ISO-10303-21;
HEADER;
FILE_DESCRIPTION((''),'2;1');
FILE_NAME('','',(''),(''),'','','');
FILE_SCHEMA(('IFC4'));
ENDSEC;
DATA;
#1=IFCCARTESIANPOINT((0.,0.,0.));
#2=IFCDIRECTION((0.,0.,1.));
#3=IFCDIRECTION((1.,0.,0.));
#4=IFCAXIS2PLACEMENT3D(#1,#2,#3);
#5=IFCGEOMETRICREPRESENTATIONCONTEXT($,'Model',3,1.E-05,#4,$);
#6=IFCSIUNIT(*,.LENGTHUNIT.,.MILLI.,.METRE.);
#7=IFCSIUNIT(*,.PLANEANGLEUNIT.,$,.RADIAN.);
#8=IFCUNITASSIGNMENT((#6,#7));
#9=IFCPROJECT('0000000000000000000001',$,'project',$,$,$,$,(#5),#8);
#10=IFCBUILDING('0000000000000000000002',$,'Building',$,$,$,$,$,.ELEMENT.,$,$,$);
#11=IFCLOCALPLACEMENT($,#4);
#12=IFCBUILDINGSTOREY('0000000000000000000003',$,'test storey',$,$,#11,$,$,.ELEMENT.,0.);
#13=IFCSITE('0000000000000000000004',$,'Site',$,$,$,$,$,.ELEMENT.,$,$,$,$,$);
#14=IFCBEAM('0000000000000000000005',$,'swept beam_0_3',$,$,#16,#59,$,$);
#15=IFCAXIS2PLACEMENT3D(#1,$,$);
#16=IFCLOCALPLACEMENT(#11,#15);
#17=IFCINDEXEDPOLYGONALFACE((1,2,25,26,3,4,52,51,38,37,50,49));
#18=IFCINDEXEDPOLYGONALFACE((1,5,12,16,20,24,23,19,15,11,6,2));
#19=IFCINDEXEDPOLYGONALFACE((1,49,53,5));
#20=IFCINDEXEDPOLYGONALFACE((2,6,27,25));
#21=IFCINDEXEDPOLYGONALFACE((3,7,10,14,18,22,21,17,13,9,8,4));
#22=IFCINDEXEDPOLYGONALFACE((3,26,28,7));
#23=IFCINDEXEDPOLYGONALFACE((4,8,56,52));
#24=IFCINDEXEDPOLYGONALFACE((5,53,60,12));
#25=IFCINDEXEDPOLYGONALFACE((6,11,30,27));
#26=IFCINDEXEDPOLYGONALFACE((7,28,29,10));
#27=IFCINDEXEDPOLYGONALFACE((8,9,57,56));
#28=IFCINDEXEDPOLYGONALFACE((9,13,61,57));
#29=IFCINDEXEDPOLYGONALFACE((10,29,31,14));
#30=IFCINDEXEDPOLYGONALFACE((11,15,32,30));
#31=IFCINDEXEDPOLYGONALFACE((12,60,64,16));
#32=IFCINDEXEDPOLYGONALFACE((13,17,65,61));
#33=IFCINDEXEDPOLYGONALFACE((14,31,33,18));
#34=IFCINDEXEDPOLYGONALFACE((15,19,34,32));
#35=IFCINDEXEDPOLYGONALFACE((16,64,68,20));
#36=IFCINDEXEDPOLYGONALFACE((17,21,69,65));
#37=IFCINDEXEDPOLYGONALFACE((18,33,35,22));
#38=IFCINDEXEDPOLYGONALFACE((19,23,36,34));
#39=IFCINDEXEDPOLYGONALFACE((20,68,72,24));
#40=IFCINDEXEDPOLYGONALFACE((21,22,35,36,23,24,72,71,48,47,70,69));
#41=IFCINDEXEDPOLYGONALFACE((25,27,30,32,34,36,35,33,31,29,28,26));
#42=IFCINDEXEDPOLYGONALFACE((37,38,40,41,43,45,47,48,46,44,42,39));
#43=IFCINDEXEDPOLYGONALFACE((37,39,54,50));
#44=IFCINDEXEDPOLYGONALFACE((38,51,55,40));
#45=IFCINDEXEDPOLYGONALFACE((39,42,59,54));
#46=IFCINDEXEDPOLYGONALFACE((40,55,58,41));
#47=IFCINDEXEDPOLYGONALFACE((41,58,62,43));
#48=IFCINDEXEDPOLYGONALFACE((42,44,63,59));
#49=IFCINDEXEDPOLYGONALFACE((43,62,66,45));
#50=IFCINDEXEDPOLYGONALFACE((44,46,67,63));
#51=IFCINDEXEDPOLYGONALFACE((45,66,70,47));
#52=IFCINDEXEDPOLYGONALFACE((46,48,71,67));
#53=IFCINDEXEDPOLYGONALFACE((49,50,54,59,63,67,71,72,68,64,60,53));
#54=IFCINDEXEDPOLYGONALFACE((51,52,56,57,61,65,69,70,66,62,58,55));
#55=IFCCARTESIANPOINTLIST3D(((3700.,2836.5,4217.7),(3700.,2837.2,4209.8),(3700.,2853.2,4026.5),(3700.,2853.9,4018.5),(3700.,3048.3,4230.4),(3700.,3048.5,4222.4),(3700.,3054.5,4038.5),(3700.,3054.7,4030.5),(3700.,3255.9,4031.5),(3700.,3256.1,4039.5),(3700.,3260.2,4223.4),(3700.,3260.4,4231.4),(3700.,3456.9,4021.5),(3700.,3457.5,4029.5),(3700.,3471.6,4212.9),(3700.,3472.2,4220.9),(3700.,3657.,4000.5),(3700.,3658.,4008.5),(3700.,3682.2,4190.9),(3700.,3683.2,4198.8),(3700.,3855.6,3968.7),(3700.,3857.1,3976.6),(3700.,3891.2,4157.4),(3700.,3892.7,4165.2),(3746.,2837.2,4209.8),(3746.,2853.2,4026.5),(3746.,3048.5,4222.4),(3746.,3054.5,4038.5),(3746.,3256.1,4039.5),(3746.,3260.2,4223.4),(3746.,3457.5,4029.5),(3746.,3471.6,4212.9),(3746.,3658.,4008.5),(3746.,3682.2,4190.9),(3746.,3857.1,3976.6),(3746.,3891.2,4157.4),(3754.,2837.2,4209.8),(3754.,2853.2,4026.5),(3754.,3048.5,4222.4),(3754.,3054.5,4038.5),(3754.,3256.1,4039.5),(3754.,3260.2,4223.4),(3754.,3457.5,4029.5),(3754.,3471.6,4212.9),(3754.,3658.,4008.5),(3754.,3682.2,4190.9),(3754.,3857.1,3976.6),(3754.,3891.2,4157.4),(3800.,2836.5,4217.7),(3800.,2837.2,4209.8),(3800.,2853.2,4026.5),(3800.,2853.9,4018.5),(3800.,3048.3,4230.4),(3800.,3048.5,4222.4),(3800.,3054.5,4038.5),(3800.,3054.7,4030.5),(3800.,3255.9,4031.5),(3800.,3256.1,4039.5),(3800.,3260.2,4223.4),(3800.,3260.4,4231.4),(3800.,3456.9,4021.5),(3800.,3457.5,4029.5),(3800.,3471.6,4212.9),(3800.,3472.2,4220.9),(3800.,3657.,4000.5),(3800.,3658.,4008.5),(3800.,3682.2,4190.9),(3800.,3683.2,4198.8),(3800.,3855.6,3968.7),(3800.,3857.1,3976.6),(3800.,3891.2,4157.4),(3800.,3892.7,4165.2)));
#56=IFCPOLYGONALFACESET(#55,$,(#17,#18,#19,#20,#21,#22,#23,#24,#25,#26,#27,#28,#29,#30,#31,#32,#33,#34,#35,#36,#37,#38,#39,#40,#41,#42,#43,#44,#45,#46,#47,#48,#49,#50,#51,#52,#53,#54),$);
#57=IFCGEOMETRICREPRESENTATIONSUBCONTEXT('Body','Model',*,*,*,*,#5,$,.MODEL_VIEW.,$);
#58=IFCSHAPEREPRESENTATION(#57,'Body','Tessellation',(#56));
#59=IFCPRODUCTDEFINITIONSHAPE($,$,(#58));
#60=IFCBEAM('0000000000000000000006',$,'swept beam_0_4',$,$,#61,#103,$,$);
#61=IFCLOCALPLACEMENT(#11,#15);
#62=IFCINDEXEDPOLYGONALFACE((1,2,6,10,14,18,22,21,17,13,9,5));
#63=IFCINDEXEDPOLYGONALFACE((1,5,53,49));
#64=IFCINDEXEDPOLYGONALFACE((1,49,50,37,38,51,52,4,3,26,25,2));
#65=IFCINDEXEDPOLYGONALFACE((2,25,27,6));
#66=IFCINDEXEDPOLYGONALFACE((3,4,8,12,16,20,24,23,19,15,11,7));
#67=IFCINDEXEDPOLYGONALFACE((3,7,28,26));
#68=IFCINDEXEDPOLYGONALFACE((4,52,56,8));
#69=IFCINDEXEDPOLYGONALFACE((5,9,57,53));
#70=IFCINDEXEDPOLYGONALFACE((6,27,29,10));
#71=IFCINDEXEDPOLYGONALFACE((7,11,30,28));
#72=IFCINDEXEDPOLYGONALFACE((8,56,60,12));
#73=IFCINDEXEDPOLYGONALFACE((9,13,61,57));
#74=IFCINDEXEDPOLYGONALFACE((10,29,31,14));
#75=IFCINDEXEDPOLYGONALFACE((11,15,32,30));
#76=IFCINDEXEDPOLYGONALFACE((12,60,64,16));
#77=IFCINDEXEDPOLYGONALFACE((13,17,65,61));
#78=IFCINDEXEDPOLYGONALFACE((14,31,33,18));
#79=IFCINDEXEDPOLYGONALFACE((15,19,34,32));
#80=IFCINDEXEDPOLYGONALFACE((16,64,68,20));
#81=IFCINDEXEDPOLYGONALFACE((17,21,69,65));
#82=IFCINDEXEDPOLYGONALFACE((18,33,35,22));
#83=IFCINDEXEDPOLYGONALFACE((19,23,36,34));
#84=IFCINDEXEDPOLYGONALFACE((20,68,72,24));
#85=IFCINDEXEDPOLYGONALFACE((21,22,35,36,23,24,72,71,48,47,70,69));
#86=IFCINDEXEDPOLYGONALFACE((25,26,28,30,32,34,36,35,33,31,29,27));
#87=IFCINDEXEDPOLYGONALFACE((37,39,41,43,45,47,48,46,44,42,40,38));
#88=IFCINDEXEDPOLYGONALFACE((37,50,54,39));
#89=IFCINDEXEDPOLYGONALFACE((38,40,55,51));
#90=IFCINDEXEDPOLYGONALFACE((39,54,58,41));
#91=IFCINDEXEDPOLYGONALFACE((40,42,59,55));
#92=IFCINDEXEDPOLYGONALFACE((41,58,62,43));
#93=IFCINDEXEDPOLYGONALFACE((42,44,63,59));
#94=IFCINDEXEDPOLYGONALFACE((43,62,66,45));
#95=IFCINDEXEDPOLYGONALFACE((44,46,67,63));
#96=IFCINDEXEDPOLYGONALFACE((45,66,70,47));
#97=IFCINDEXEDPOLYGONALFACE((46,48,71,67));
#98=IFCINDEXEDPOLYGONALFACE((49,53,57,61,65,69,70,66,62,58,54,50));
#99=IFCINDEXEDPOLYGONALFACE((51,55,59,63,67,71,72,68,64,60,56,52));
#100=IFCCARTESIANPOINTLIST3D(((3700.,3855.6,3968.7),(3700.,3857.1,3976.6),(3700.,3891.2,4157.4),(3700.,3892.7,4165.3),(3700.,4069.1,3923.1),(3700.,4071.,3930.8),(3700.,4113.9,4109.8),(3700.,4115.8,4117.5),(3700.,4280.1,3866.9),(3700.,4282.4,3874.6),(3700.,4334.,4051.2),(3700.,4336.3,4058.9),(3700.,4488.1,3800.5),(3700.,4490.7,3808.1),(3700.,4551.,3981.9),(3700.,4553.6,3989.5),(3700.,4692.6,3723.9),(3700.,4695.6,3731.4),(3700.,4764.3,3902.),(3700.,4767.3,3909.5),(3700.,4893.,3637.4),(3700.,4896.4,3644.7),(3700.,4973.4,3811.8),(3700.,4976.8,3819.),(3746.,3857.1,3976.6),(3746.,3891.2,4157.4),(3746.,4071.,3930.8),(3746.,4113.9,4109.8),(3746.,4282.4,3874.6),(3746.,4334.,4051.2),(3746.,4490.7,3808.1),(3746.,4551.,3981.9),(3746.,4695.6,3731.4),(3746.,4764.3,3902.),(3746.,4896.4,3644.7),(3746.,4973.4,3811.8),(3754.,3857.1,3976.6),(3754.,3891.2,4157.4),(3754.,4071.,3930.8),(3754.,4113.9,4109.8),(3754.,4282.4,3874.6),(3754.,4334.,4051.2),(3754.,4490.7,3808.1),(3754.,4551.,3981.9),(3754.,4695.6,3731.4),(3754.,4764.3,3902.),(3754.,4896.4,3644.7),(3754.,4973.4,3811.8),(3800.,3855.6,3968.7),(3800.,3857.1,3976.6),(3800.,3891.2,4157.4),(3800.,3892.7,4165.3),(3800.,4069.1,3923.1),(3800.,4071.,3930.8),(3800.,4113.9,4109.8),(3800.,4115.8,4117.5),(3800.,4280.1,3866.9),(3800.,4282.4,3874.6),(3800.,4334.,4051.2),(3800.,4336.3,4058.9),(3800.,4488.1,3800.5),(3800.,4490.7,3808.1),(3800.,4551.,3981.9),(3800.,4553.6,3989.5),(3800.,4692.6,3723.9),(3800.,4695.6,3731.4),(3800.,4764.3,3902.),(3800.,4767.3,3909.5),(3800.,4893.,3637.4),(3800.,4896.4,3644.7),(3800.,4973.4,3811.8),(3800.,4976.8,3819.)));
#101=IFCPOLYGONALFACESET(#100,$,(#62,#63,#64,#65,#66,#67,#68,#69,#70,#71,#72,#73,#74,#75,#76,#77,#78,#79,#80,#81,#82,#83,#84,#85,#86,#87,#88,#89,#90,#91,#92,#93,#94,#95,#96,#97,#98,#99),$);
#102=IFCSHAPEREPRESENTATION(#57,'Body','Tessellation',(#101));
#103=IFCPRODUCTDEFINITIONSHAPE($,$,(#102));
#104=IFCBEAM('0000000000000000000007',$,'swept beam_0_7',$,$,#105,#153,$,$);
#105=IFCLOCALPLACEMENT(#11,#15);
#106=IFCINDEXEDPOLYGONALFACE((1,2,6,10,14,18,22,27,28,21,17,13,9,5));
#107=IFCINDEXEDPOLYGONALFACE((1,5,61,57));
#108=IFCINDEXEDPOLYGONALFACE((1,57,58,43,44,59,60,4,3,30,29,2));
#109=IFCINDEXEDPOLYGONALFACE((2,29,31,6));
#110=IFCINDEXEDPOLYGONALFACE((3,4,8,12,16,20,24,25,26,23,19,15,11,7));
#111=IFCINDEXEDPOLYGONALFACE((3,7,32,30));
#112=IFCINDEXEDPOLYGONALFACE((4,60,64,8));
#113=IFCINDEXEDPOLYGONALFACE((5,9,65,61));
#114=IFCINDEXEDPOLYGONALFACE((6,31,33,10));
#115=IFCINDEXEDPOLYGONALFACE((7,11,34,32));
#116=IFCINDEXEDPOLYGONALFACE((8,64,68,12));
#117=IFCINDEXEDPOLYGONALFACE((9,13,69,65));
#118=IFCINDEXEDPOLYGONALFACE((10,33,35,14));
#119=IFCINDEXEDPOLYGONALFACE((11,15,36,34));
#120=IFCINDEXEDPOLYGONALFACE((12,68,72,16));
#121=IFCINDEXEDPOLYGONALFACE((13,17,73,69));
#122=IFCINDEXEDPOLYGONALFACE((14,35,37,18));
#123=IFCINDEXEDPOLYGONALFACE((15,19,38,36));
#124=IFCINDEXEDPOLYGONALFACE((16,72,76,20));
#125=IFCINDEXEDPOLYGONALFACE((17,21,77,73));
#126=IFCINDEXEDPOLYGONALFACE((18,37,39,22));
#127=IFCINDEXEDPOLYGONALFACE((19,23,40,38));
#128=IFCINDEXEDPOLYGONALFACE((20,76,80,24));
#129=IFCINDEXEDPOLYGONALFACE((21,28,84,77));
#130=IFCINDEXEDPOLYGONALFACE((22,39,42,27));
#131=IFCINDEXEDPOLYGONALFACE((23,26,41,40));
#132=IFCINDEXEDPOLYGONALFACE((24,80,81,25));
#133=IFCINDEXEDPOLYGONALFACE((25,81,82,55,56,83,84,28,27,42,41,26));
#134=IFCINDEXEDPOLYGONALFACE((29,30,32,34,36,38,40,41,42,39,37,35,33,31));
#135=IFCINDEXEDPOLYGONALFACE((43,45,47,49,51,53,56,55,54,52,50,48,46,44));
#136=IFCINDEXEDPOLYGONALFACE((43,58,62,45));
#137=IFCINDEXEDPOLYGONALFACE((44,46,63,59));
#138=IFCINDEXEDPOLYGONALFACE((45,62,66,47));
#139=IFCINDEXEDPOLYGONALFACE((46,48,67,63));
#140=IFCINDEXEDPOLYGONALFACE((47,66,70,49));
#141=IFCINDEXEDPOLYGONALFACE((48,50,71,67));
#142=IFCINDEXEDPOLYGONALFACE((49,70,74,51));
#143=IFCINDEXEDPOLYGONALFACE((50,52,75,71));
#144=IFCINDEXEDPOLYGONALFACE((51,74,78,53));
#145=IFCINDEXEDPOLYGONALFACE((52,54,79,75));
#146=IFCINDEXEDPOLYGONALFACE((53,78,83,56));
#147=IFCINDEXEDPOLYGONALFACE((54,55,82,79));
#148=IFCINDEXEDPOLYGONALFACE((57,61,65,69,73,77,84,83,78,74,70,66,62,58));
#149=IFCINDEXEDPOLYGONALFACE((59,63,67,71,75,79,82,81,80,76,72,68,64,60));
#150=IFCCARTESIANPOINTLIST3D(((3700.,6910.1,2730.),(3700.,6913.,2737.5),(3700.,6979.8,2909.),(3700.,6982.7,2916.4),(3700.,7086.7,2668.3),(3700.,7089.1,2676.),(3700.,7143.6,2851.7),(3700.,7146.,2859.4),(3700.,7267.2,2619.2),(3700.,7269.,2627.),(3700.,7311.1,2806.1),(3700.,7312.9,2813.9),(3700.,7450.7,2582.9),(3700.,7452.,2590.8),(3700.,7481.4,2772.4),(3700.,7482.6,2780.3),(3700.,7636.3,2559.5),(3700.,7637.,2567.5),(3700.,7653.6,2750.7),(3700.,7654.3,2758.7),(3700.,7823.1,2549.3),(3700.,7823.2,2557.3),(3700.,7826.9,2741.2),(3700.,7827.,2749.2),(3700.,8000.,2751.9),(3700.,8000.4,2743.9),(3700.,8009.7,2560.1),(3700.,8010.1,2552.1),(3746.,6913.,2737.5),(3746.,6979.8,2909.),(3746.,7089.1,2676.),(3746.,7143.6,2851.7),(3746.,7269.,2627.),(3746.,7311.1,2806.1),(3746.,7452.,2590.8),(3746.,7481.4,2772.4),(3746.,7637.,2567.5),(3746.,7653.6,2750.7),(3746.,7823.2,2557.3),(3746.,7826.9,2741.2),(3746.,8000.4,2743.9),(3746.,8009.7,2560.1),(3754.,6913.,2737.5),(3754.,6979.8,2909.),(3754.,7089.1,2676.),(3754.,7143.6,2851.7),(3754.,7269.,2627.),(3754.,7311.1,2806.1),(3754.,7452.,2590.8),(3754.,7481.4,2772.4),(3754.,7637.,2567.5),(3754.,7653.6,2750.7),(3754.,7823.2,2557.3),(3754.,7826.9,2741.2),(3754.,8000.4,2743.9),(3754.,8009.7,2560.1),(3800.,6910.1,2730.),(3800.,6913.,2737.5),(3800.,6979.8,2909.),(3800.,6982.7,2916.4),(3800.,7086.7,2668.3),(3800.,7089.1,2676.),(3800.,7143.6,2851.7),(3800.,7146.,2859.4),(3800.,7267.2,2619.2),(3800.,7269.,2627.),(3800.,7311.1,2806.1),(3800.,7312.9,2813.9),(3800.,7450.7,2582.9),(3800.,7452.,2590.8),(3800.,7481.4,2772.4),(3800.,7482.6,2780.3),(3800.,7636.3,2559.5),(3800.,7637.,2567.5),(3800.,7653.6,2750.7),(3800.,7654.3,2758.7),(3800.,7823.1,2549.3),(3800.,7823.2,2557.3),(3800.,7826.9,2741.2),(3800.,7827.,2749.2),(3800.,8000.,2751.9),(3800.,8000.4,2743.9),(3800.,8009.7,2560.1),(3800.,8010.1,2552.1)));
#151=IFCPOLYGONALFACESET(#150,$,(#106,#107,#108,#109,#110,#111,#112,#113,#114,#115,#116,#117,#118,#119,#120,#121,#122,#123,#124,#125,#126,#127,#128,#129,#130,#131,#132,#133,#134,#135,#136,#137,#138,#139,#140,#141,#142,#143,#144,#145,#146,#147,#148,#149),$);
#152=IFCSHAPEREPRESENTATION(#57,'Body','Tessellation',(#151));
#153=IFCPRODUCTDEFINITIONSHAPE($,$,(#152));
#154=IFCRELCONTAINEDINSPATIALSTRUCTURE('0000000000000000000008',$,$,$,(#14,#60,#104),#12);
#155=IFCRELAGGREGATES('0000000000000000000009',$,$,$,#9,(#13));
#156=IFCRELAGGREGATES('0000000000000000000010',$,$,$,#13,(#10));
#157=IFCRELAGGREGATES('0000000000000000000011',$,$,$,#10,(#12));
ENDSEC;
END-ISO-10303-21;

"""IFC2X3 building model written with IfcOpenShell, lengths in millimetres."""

from ifc_helpers import new_model, entity, si_unit, origin_with_axes, place, context, subcontext, project, spatial, element, save


model = new_model("IFC2X3")

# Units and contexts
model_context = context("Model", 3, precision=1e-05, world=origin_with_axes())
body_context = subcontext(model_context, "Body", "Model", "MODEL_VIEW")
ifc_project = project(units=[si_unit("LENGTHUNIT", "METRE", prefix="MILLI"), si_unit("PLANEANGLEUNIT", "RADIAN")], contexts=[model_context])

# Site, building, storey
site = spatial("IfcSite", under=ifc_project, Name="Site", CompositionType="ELEMENT")
building = spatial("IfcBuilding", under=site, Name="Building", CompositionType="ELEMENT")
storey_placement = place(None, origin_with_axes())
storey = spatial("IfcBuildingStorey", under=building, at=storey_placement, Name="test storey", CompositionType="ELEMENT", Elevation=0.0)

# Beams
beam_1_placement = place(storey_placement, origin_with_axes())
element("IfcBeam", 1, at=beam_1_placement, inside=storey, Name="swept beam_0_3", context=body_context, shape_type="SweptSolid", body=[
    entity("IfcRevolvedAreaSolid", entity("IfcArbitraryClosedProfileDef", "AREA", None, entity("IfcPolyline", [entity("IfcCartesianPoint", [-192.0, -50.0]), entity("IfcCartesianPoint", [-192.0, -4.0]), entity("IfcCartesianPoint", [-8.0, -4.0]), entity("IfcCartesianPoint", [-8.0, -50.0]), entity("IfcCartesianPoint", [0.0, -50.0]), entity("IfcCartesianPoint", [0.0, 50.0]), entity("IfcCartesianPoint", [-8.0, 50.0]), entity("IfcCartesianPoint", [-8.0, 4.0]), entity("IfcCartesianPoint", [-192.0, 4.0]), entity("IfcCartesianPoint", [-192.0, 50.0]), entity("IfcCartesianPoint", [-200.0, 50.0]), entity("IfcCartesianPoint", [-200.0, -50.0]), entity("IfcCartesianPoint", [-192.0, -50.0])])), entity("IfcAxis2Placement3D", entity("IfcCartesianPoint", [3750.0, 2836.5, 4217.7]), entity("IfcDirection", [0.0, -0.9962, -0.0868]), entity("IfcDirection", [0.0, -0.0868, 0.9962])), entity("IfcAxis1Placement", entity("IfcCartesianPoint", [-3883.8, 0.0, 0.0]), entity("IfcDirection", [0.0, 1.0, 0.0])), 0.273121),
])
beam_2_placement = place(storey_placement, origin_with_axes())
element("IfcBeam", 2, at=beam_2_placement, inside=storey, Name="swept beam_0_4", context=body_context, shape_type="SweptSolid", body=[
    entity("IfcRevolvedAreaSolid", entity("IfcArbitraryClosedProfileDef", "AREA", None, entity("IfcPolyline", [entity("IfcCartesianPoint", [-192.0, -50.0]), entity("IfcCartesianPoint", [-192.0, -4.0]), entity("IfcCartesianPoint", [-8.0, -4.0]), entity("IfcCartesianPoint", [-8.0, -50.0]), entity("IfcCartesianPoint", [0.0, -50.0]), entity("IfcCartesianPoint", [0.0, 50.0]), entity("IfcCartesianPoint", [-8.0, 50.0]), entity("IfcCartesianPoint", [-8.0, 4.0]), entity("IfcCartesianPoint", [-192.0, 4.0]), entity("IfcCartesianPoint", [-192.0, 50.0]), entity("IfcCartesianPoint", [-200.0, 50.0]), entity("IfcCartesianPoint", [-200.0, -50.0]), entity("IfcCartesianPoint", [-192.0, -50.0])])), entity("IfcAxis2Placement3D", entity("IfcCartesianPoint", [3750.0, 3892.7, 4165.3]), entity("IfcDirection", [0.0, -0.9827, 0.1851]), entity("IfcDirection", [0.0, 0.1851, 0.9827])), entity("IfcAxis1Placement", entity("IfcCartesianPoint", [-4639.6, 0.0, 0.0]), entity("IfcDirection", [0.0, 1.0, 0.0])), 0.24591),
])
beam_3_placement = place(storey_placement, origin_with_axes())
element("IfcBeam", 3, at=beam_3_placement, inside=storey, Name="swept beam_0_7", context=body_context, shape_type="SweptSolid", body=[
    entity("IfcRevolvedAreaSolid", entity("IfcArbitraryClosedProfileDef", "AREA", None, entity("IfcPolyline", [entity("IfcCartesianPoint", [192.0, 50.0]), entity("IfcCartesianPoint", [192.0, 4.0]), entity("IfcCartesianPoint", [8.0, 4.0]), entity("IfcCartesianPoint", [8.0, 50.0]), entity("IfcCartesianPoint", [0.0, 50.0]), entity("IfcCartesianPoint", [0.0, -50.0]), entity("IfcCartesianPoint", [8.0, -50.0]), entity("IfcCartesianPoint", [8.0, -4.0]), entity("IfcCartesianPoint", [192.0, -4.0]), entity("IfcCartesianPoint", [192.0, -50.0]), entity("IfcCartesianPoint", [200.0, -50.0]), entity("IfcCartesianPoint", [200.0, 50.0]), entity("IfcCartesianPoint", [192.0, 50.0])])), entity("IfcAxis2Placement3D", entity("IfcCartesianPoint", [3750.0, 6982.7, 2916.4]), entity("IfcDirection", [0.0, -0.9319, 0.3628]), entity("IfcDirection", [0.0, -0.3628, -0.9319])), entity("IfcAxis1Placement", entity("IfcCartesianPoint", [-2461.2, 0.0, 0.0]), entity("IfcDirection", [0.0, 1.0, 0.0])), 0.421826),
])

save(model, "model.ifc")
